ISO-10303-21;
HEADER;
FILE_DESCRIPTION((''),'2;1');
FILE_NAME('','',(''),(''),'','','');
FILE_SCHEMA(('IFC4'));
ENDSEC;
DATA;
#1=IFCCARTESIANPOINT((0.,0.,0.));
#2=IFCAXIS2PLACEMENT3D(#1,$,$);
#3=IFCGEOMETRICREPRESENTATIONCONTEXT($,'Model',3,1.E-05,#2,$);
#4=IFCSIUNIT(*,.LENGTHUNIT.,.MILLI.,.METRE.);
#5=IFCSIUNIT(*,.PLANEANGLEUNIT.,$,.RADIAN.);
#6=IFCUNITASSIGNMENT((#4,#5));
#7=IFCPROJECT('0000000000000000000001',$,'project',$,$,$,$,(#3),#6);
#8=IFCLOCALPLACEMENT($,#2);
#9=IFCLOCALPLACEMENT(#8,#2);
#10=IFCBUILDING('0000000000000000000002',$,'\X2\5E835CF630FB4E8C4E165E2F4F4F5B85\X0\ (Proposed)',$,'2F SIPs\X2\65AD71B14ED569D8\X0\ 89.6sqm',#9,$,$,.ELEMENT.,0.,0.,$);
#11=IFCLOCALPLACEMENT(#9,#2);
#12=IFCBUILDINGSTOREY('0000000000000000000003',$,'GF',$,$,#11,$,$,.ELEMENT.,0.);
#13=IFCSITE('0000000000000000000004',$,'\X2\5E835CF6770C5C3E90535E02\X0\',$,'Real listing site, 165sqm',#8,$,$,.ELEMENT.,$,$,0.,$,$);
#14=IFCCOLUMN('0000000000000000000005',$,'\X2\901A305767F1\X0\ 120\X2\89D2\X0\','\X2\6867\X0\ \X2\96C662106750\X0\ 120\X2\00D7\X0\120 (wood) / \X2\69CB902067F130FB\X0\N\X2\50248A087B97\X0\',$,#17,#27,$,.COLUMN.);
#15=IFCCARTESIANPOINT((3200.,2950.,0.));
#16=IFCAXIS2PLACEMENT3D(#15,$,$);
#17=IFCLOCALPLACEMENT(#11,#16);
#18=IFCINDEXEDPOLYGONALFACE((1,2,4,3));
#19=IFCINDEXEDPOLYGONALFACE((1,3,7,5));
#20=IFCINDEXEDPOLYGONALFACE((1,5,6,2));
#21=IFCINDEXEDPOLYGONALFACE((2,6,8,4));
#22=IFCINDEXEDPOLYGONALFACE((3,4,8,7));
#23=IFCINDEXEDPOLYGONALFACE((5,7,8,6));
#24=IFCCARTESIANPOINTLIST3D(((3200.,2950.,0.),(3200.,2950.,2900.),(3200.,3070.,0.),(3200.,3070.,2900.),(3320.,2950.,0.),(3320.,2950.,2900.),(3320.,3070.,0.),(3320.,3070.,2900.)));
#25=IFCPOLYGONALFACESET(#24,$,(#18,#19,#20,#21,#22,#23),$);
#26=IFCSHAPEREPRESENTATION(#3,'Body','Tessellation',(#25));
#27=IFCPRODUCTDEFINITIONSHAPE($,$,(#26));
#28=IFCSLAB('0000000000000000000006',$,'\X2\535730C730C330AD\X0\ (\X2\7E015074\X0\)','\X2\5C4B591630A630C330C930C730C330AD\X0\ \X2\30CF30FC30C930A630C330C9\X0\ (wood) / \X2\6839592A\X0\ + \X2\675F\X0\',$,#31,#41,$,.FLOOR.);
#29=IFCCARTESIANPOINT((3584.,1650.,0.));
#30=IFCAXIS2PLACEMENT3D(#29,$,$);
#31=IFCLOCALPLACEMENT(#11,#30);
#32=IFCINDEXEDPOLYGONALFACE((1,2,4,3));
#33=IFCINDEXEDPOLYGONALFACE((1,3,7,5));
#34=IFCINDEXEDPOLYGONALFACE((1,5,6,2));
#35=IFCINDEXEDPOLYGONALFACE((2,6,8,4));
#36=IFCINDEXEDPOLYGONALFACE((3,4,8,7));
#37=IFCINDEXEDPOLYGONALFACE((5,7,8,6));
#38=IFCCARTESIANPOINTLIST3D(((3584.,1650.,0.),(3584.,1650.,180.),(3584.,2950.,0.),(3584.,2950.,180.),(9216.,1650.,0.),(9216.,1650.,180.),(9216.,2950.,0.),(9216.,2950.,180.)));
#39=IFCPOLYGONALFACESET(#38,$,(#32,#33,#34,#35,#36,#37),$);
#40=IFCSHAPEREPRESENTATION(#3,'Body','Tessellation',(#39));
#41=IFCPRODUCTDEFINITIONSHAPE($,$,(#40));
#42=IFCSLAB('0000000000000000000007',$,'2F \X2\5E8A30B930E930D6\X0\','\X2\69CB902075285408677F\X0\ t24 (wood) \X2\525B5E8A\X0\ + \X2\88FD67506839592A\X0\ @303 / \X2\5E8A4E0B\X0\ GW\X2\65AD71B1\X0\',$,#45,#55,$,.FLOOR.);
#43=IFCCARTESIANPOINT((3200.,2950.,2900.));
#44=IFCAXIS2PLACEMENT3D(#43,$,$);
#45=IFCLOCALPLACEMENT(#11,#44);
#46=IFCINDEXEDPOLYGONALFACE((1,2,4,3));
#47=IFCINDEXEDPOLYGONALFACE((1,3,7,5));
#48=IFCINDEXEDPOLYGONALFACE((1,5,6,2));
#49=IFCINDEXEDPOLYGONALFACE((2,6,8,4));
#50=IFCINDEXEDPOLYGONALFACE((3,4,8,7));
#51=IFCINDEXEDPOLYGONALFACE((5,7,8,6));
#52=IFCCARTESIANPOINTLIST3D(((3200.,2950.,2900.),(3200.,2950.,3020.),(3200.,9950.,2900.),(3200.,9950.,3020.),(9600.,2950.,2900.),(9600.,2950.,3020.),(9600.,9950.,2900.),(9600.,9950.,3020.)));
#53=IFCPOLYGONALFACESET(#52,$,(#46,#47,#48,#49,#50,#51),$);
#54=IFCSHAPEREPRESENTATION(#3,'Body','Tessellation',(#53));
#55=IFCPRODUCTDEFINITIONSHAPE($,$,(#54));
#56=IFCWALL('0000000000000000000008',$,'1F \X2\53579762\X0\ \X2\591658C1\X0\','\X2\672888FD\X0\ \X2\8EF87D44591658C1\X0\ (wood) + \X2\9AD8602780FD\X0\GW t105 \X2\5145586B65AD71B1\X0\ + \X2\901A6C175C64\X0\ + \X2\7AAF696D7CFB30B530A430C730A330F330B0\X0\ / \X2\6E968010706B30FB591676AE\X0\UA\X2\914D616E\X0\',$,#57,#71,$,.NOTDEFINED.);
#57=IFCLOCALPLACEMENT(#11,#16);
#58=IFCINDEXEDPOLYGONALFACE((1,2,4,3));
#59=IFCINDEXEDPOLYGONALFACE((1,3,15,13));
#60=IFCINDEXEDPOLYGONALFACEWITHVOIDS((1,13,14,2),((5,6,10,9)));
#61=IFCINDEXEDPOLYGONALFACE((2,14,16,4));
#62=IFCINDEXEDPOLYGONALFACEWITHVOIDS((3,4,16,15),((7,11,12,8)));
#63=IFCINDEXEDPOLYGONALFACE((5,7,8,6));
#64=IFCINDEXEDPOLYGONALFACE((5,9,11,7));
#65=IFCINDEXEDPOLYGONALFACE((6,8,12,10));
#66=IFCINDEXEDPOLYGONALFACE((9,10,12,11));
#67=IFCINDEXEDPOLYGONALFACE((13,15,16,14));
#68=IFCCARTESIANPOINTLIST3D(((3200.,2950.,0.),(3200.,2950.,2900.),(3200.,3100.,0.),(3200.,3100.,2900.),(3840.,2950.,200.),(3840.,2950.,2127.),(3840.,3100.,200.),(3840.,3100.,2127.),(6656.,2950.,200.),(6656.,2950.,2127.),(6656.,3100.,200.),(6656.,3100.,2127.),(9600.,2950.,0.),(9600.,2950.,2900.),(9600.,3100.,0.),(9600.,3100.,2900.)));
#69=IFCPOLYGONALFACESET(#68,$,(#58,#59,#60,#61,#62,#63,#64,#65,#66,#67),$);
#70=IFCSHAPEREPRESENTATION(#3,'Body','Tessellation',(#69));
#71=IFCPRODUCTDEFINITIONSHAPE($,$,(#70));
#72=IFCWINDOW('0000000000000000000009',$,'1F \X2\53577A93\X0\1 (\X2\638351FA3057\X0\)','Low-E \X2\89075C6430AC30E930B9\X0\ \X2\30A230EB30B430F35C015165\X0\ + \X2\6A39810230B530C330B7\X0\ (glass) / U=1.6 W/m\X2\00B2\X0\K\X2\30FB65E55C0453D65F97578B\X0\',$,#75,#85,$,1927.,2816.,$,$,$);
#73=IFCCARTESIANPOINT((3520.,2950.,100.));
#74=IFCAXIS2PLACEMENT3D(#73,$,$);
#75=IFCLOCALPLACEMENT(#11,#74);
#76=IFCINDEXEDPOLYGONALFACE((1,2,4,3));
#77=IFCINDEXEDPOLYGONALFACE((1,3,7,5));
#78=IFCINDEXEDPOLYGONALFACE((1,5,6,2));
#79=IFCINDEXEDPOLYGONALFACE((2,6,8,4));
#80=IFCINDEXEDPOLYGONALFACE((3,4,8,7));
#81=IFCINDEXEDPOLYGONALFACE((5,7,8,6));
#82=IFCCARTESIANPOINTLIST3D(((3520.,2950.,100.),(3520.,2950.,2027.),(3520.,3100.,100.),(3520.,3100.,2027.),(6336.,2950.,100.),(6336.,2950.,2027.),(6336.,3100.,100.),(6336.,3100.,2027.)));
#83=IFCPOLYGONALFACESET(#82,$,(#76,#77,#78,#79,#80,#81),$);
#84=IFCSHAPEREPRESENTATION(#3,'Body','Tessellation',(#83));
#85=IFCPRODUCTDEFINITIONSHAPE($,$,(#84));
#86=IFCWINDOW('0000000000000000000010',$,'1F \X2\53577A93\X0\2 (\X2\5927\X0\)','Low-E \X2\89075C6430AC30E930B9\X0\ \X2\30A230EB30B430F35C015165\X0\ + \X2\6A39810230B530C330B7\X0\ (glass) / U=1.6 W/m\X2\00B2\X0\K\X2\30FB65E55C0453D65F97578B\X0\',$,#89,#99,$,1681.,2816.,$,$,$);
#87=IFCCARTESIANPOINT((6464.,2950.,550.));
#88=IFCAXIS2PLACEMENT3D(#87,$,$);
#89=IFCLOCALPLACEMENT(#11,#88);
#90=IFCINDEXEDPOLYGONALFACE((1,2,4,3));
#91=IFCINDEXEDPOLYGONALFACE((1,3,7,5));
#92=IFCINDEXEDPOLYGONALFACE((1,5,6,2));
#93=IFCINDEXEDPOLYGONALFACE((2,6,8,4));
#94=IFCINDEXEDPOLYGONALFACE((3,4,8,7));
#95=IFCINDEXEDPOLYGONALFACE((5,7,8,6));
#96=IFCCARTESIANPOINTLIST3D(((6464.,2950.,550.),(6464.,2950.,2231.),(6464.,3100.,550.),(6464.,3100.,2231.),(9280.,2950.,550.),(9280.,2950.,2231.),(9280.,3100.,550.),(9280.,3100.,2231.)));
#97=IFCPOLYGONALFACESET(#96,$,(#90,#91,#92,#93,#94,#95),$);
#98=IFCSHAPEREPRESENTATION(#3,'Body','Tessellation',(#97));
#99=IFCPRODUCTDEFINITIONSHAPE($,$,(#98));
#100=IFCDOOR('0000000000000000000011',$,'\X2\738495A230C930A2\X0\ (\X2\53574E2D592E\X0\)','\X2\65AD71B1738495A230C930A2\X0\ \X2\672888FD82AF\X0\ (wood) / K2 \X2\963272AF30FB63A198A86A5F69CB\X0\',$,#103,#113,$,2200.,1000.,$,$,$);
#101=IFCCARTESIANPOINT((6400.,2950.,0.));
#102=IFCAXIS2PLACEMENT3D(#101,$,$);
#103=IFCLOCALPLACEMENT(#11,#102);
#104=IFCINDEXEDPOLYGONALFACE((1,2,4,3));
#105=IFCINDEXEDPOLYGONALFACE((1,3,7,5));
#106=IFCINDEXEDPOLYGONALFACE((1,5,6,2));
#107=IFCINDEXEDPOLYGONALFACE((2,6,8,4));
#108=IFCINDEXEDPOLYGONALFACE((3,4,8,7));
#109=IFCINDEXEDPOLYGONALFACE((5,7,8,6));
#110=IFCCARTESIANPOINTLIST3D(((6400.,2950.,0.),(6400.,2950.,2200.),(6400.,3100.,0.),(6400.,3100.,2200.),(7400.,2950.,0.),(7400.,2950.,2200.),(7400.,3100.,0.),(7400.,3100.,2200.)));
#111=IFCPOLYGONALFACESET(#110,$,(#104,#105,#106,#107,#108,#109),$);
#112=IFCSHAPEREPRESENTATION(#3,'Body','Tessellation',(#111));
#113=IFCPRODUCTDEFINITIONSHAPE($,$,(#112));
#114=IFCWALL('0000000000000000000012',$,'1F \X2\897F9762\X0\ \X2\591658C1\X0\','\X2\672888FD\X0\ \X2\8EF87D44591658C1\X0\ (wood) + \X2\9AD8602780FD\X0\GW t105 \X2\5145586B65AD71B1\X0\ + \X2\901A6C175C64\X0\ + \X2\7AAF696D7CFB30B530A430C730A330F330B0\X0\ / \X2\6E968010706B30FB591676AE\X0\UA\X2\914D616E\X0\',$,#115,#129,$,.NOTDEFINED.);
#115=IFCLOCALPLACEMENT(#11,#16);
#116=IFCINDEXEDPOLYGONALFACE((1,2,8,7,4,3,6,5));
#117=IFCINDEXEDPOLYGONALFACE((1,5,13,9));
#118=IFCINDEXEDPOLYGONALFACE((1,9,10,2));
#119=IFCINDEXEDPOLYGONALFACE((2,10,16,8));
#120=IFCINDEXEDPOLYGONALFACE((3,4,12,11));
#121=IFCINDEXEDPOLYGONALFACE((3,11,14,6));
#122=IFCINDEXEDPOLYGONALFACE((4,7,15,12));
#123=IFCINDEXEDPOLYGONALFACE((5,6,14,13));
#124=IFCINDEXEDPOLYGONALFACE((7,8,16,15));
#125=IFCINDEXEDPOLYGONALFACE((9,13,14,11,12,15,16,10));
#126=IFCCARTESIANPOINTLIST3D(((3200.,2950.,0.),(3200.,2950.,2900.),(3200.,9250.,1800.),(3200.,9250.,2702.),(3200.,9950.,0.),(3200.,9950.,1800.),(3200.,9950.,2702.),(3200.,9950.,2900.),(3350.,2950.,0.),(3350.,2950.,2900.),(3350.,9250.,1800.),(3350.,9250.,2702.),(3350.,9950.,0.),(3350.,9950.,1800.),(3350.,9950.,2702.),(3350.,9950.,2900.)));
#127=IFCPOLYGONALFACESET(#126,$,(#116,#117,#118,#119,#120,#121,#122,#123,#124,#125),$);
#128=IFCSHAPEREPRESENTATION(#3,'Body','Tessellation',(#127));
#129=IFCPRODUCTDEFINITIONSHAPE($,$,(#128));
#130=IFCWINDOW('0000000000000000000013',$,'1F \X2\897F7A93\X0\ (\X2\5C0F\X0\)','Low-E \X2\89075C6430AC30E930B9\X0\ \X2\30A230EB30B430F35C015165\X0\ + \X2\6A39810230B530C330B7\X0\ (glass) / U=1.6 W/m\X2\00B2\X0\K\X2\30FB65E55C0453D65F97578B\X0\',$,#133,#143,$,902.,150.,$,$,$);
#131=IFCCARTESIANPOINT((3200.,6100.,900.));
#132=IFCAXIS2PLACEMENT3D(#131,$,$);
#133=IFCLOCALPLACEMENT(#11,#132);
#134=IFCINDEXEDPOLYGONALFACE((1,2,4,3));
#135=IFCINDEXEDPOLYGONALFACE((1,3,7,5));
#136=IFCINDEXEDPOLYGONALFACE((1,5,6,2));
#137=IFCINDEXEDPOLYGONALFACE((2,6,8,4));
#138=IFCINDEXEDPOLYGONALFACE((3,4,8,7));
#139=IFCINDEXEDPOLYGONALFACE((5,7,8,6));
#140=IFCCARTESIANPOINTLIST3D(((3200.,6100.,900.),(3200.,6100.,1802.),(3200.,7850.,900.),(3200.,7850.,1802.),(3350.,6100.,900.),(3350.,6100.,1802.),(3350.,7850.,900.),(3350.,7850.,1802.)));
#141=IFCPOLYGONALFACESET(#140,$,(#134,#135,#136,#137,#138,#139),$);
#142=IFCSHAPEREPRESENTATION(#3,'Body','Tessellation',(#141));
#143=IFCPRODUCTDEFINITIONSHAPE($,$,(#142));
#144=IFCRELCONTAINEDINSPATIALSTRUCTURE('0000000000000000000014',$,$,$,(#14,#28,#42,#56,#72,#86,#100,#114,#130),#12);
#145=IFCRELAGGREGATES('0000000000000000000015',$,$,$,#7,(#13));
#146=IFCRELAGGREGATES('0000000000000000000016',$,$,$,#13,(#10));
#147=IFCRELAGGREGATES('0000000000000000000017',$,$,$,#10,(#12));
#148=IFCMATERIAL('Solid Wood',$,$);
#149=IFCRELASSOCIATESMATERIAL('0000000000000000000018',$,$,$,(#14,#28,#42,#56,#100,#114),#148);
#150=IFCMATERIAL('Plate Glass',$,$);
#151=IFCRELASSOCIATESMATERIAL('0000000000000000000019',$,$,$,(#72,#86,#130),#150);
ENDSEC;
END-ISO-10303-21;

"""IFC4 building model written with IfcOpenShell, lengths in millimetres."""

from ifc_helpers import new_model, si_unit, frame, frame_2d, origin, place, context, project, spatial, rectangle, extrude, material, element, fill, save


model = new_model("IFC4")

# Units and contexts
model_context = context("Model", 3, precision=1e-05, world=origin())
ifc_project = project(units=[si_unit("LENGTHUNIT", "METRE", prefix="MILLI"), si_unit("PLANEANGLEUNIT", "RADIAN")], contexts=[model_context])

# Site, building, storey
site_placement = place(None, origin())
site = spatial("IfcSite", under=ifc_project, at=site_placement, Name="広島県尾道市", ObjectType="Real listing site, 165sqm", CompositionType="ELEMENT", RefElevation=0.0)
building_placement = place(site_placement, origin())
building = spatial("IfcBuilding", under=site, at=building_placement, Name="広島・二世帯住宅 (Proposed)", ObjectType="2F SIPs断熱仕様 89.6sqm", CompositionType="ELEMENT", ElevationOfRefHeight=0.0, ElevationOfTerrain=0.0)
storey_placement = place(building_placement, origin())
storey = spatial("IfcBuildingStorey", under=building, at=storey_placement, Name="GF", CompositionType="ELEMENT", Elevation=0.0)

# Column
ifc_material_1 = material(Name="Solid Wood")
column_placement = place(storey_placement, frame((3200.0, 2950.0, 0.0)))
element("IfcColumn", 1, at=column_placement, inside=storey, material=ifc_material_1, Name="通し柱 120角", Description="桧 集成材 120×120 (wood) / 構造柱・N値計算", PredefinedType="COLUMN", context=model_context, shape_type="SweptSolid", body=[
    extrude(rectangle(XDim=120.0, YDim=120.0, at=frame_2d((60.0, 60.0))), frame((3200.0, 2950.0, 0.0)), (0.0, 0.0, 1.0), 2900.0),
])

# Slabs
slab_1_placement = place(storey_placement, frame((3584.0, 1650.0, 0.0)))
element("IfcSlab", 2, at=slab_1_placement, inside=storey, material=ifc_material_1, Name="南デッキ (縁側)", Description="屋外ウッドデッキ ハードウッド (wood) / 根太 + 束", PredefinedType="FLOOR", context=model_context, shape_type="SweptSolid", body=[
    extrude(rectangle(XDim=5632.0, YDim=1300.0, at=frame_2d((2816.0, 650.0))), frame((3584.0, 1650.0, 0.0)), (0.0, 0.0, 1.0), 180.0),
])
slab_2_placement = place(storey_placement, frame((3200.0, 2950.0, 2900.0)))
element("IfcSlab", 3, at=slab_2_placement, inside=storey, material=ifc_material_1, Name="2F 床スラブ", Description="構造用合板 t24 (wood) 剛床 + 製材根太 @303 / 床下 GW断熱", PredefinedType="FLOOR", context=model_context, shape_type="SweptSolid", body=[
    extrude(rectangle(XDim=6400.0, YDim=7000.0, at=frame_2d((3200.0, 3500.0))), frame((3200.0, 2950.0, 2900.0)), (0.0, 0.0, 1.0), 120.0),
])

# Wall, openings, windows, door
wall_1_placement = place(storey_placement, frame((3200.0, 2950.0, 0.0)))
wall_1 = element("IfcWall", 4, at=wall_1_placement, inside=storey, material=ifc_material_1, Name="1F 南面 外壁", Description="木製 軸組外壁 (wood) + 高性能GW t105 充填断熱 + 通気層 + 窯業系サイディング / 準耐火・外皮UA配慮", PredefinedType="NOTDEFINED", context=model_context, shape_type="SweptSolid", body=[
    extrude(rectangle(XDim=6400.0, YDim=150.0, at=frame_2d((3200.0, 75.0))), frame((3200.0, 2950.0, 0.0)), (0.0, 0.0, 1.0), 2900.0),
])
opening_1_placement = place(storey_placement, frame((3520.0, 2950.0, 100.0)))
opening_1 = element("IfcOpeningElement", 5, at=opening_1_placement, cuts=wall_1, PredefinedType="NOTDEFINED", context=model_context, shape_type="SweptSolid", body=[
    extrude(rectangle(XDim=2816.0, YDim=150.0, at=frame_2d((1408.0, 75.0))), frame((3520.0, 2950.0, 100.0)), (0.0, 0.0, 1.0), 1927.0),
])
opening_2_placement = place(storey_placement, frame((6464.0, 2950.0, 550.0)))
opening_2 = element("IfcOpeningElement", 6, at=opening_2_placement, cuts=wall_1, PredefinedType="NOTDEFINED", context=model_context, shape_type="SweptSolid", body=[
    extrude(rectangle(XDim=2816.0, YDim=150.0, at=frame_2d((1408.0, 75.0))), frame((6464.0, 2950.0, 550.0)), (0.0, 0.0, 1.0), 1681.0),
])
opening_3_placement = place(storey_placement, frame((6400.0, 2950.0, 0.0)))
opening_3 = element("IfcOpeningElement", 7, at=opening_3_placement, cuts=wall_1, PredefinedType="NOTDEFINED", context=model_context, shape_type="SweptSolid", body=[
    extrude(rectangle(XDim=1000.0, YDim=150.0, at=frame_2d((500.0, 75.0))), frame((6400.0, 2950.0, 0.0)), (0.0, 0.0, 1.0), 2200.0),
])
ifc_material_2 = material(Name="Plate Glass")
window_1_placement = place(storey_placement, frame((3520.0, 2950.0, 100.0)))
window_1 = element("IfcWindow", 8, at=window_1_placement, inside=storey, material=ifc_material_2, Name="1F 南窓1 (掃出し)", Description="Low-E 複層ガラス アルゴン封入 + 樹脂サッシ (glass) / U=1.6 W/m²K・日射取得型", OverallHeight=1927.0, OverallWidth=2816.0, context=model_context, shape_type="SweptSolid", body=[
    extrude(rectangle(XDim=2816.0, YDim=150.0, at=frame_2d((1408.0, 75.0))), frame((3520.0, 2950.0, 100.0)), (0.0, 0.0, 1.0), 1927.0),
])
fill(opening_1, window_1)
window_2_placement = place(storey_placement, frame((6464.0, 2950.0, 550.0)))
window_2 = element("IfcWindow", 9, at=window_2_placement, inside=storey, material=ifc_material_2, Name="1F 南窓2 (大)", Description="Low-E 複層ガラス アルゴン封入 + 樹脂サッシ (glass) / U=1.6 W/m²K・日射取得型", OverallHeight=1681.0, OverallWidth=2816.0, context=model_context, shape_type="SweptSolid", body=[
    extrude(rectangle(XDim=2816.0, YDim=150.0, at=frame_2d((1408.0, 75.0))), frame((6464.0, 2950.0, 550.0)), (0.0, 0.0, 1.0), 1681.0),
])
fill(opening_2, window_2)
door_placement = place(storey_placement, frame((6400.0, 2950.0, 0.0)))
door = element("IfcDoor", 10, at=door_placement, inside=storey, material=ifc_material_1, Name="玄関ドア (南中央)", Description="断熱玄関ドア 木製芯 (wood) / K2 防犯・採風機構", OverallHeight=2200.0, OverallWidth=1000.0, context=model_context, shape_type="SweptSolid", body=[
    extrude(rectangle(XDim=1000.0, YDim=150.0, at=frame_2d((500.0, 75.0))), frame((6400.0, 2950.0, 0.0)), (0.0, 0.0, 1.0), 2200.0),
])
fill(opening_3, door)

# Wall, opening, window
wall_2_placement = place(storey_placement, frame((3200.0, 2950.0, 0.0)))
wall_2 = element("IfcWall", 11, at=wall_2_placement, inside=storey, material=ifc_material_1, Name="1F 西面 外壁", Description="木製 軸組外壁 (wood) + 高性能GW t105 充填断熱 + 通気層 + 窯業系サイディング / 準耐火・外皮UA配慮", PredefinedType="NOTDEFINED", context=model_context, shape_type="SweptSolid", body=[
    extrude(rectangle(XDim=150.0, YDim=7000.0, at=frame_2d((75.0, 3500.0))), frame((3200.0, 2950.0, 0.0)), (0.0, 0.0, 1.0), 2900.0),
])
opening_4_placement = place(storey_placement, frame((3200.0, 6100.0, 900.0)))
opening_4 = element("IfcOpeningElement", 12, at=opening_4_placement, cuts=wall_2, PredefinedType="NOTDEFINED", context=model_context, shape_type="SweptSolid", body=[
    extrude(rectangle(XDim=150.0, YDim=1750.0, at=frame_2d((75.0, 875.0))), frame((3200.0, 6100.0, 900.0)), (0.0, 0.0, 1.0), 902.0),
])
window_3_placement = place(storey_placement, frame((3200.0, 6100.0, 900.0)))
window_3 = element("IfcWindow", 13, at=window_3_placement, inside=storey, material=ifc_material_2, Name="1F 西窓 (小)", Description="Low-E 複層ガラス アルゴン封入 + 樹脂サッシ (glass) / U=1.6 W/m²K・日射取得型", OverallHeight=902.0, OverallWidth=150.0, context=model_context, shape_type="SweptSolid", body=[
    extrude(rectangle(XDim=150.0, YDim=1750.0, at=frame_2d((75.0, 875.0))), frame((3200.0, 6100.0, 900.0)), (0.0, 0.0, 1.0), 902.0),
])
fill(opening_4, window_3)

save(model, "model.ifc")
